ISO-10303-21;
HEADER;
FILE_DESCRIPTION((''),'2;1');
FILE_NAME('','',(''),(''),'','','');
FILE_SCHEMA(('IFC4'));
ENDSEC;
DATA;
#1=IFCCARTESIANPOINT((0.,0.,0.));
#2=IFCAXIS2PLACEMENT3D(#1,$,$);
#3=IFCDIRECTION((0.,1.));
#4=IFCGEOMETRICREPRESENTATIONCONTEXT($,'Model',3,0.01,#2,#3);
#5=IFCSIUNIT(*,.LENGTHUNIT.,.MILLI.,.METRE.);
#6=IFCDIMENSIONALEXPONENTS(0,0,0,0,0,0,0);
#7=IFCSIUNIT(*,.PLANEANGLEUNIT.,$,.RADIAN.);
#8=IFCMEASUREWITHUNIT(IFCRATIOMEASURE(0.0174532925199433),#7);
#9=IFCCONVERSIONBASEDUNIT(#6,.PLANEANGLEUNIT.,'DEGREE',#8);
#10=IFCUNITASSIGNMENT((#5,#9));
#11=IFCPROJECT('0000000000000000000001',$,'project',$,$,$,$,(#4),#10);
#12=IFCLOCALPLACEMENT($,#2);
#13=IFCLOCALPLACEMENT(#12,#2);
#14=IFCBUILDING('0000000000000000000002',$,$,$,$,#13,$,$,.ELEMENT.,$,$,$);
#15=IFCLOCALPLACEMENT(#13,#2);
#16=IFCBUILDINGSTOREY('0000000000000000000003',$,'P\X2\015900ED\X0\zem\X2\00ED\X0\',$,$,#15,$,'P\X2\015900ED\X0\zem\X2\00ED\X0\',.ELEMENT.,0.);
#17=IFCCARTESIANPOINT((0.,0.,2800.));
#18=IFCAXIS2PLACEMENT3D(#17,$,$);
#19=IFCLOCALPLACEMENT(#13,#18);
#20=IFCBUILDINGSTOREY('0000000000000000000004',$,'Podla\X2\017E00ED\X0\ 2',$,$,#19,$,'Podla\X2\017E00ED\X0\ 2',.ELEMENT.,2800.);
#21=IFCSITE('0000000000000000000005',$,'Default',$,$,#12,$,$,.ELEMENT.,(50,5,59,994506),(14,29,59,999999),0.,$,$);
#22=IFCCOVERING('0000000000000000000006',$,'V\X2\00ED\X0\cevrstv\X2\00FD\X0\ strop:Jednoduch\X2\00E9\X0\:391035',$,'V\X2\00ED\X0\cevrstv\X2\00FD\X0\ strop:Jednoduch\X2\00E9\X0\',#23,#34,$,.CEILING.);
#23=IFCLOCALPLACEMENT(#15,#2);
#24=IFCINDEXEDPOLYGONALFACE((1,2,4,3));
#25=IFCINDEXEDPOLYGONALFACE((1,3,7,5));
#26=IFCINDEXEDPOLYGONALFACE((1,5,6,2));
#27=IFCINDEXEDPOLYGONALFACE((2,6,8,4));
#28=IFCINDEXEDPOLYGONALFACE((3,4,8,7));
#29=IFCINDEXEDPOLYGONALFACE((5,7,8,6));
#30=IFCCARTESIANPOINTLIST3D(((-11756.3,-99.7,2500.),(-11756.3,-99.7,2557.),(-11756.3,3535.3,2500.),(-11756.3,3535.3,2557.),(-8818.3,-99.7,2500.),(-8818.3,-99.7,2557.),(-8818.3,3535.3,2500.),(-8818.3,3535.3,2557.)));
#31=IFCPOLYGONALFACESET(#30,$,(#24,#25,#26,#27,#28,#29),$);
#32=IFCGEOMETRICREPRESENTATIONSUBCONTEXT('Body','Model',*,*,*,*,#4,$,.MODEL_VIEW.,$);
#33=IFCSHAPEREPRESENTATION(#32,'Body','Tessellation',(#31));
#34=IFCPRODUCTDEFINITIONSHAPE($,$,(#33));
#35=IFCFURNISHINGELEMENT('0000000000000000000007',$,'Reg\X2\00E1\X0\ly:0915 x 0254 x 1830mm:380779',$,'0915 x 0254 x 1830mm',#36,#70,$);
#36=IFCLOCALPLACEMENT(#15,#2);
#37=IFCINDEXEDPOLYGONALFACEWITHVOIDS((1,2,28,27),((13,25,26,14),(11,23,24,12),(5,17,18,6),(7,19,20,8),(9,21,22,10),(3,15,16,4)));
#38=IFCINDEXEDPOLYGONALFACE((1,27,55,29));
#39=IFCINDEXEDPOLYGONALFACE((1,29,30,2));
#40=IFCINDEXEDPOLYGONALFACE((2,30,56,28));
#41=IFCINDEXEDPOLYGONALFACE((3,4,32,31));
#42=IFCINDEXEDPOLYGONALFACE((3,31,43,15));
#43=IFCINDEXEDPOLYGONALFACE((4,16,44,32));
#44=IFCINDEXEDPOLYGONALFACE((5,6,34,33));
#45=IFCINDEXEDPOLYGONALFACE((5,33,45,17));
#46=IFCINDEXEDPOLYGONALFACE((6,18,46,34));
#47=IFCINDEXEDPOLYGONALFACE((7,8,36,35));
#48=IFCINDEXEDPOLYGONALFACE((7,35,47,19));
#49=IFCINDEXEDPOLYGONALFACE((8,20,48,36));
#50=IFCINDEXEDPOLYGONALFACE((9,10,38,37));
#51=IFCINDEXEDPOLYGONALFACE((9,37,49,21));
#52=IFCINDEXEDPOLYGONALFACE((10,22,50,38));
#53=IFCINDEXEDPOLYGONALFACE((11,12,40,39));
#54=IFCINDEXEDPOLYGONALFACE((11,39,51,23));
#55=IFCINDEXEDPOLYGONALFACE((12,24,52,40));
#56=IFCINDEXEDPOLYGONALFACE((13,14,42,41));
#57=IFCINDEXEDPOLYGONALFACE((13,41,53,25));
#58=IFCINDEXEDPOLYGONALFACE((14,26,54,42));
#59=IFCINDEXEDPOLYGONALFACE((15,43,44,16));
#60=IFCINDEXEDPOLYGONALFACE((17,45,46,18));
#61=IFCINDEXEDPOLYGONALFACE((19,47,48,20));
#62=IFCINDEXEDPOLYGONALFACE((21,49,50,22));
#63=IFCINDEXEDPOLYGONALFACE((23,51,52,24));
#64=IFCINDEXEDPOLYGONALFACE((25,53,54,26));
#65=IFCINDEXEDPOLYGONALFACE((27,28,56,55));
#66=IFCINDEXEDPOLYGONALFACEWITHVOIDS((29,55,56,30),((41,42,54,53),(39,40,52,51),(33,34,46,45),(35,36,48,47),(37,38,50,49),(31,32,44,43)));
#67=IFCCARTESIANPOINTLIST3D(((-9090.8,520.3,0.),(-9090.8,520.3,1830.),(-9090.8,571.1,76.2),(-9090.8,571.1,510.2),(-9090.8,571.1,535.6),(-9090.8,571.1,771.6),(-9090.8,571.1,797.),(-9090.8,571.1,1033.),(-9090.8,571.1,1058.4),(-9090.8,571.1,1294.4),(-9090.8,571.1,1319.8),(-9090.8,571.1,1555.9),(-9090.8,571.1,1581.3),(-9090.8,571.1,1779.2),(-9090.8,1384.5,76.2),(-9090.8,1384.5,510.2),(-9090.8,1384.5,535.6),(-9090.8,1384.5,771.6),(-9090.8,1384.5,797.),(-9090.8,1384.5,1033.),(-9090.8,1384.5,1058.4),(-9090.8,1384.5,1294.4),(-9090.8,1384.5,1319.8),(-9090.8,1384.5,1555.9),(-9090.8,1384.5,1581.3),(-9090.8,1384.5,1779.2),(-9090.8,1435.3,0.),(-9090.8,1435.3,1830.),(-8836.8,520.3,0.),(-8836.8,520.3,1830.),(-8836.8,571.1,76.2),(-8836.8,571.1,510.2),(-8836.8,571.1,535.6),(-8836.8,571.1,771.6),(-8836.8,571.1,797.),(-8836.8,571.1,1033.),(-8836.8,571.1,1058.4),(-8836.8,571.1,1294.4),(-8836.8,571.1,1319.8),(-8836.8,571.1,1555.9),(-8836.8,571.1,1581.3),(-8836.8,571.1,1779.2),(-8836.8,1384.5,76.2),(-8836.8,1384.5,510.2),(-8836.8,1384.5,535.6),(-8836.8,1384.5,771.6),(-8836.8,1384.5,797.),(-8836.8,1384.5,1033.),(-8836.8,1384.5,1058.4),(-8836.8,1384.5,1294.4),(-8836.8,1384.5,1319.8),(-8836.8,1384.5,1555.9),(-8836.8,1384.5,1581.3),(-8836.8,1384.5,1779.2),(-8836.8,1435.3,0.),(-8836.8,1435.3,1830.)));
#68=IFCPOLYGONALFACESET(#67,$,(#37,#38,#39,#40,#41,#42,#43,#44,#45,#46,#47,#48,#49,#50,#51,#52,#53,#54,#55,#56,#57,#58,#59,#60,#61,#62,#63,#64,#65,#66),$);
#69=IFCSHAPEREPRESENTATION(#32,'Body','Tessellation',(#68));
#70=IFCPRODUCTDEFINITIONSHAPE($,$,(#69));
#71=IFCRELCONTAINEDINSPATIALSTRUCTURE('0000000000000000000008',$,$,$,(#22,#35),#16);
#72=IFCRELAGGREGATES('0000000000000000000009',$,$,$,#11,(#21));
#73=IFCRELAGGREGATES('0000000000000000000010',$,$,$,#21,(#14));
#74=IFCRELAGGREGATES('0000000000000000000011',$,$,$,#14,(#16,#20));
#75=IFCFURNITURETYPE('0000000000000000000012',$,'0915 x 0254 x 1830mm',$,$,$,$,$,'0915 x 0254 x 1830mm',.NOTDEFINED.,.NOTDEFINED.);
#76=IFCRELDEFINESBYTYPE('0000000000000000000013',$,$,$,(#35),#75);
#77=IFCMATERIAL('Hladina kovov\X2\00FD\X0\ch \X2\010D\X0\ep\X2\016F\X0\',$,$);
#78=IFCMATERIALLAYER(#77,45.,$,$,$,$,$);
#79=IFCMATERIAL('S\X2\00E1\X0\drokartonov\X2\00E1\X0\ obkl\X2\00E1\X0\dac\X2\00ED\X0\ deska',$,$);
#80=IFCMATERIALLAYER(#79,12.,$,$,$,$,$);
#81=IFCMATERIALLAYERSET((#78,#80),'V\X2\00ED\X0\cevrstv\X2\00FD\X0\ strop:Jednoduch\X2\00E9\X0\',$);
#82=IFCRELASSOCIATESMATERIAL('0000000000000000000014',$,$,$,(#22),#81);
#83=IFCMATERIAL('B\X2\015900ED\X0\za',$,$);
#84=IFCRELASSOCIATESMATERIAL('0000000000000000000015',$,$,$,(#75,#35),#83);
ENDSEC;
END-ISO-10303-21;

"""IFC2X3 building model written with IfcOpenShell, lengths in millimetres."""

from ifc_helpers import new_model, entity, si_unit, converted_unit, direction, frame, frame_2d, origin, place, context, subcontext, project, spatial, polyline, rectangle, outline, extrude, source, transform, mapped, material, layer, layer_set, layer_usage, type_object, type_shapes, element, save


model = new_model("IFC2X3")

# Units and contexts
model_context = context("Model", 3, precision=0.01, world=origin(), true_north=direction((0.0, 1.0)))
body_context = subcontext(model_context, "Body", "Model", "MODEL_VIEW")
ifc_project = project(units=[si_unit("LENGTHUNIT", "METRE", prefix="MILLI"), converted_unit("PLANEANGLEUNIT", "DEGREE", entity("IfcRatioMeasure", 0.0174532925199433), si_unit("PLANEANGLEUNIT", "RADIAN"), dimensions=[0, 0, 0, 0, 0, 0, 0])], contexts=[model_context])

# Site, building, storey
site_placement = place(None, origin())
site = spatial("IfcSite", under=ifc_project, at=site_placement, Name="Default", CompositionType="ELEMENT", RefLatitude=(50, 5, 59, 994506), RefLongitude=(14, 29, 59, 999999), RefElevation=0.0)
building_placement = place(site_placement, origin())
building = spatial("IfcBuilding", under=site, at=building_placement, CompositionType="ELEMENT")
storey_1_placement = place(building_placement, origin())
storey_1 = spatial("IfcBuildingStorey", under=building, at=storey_1_placement, Name="Přízemí", LongName="Přízemí", CompositionType="ELEMENT", Elevation=0.0)

# Shared definitions
ifc_material_1 = material(Name="Sádrokartonová obkládací deska")

# Shared definitions
storey_2_placement = place(building_placement, frame((0.0, 0.0, 2800.0)))
storey_2 = spatial("IfcBuildingStorey", under=building, at=storey_2_placement, Name="Podlaží 2", LongName="Podlaží 2", CompositionType="ELEMENT", Elevation=2800.0)

# Covering
ifc_material_2 = material(Name="Hladina kovových čepů")
ifc_layer_1 = layer(ifc_material_2, 45.0)
ifc_layer_2 = layer(ifc_material_1, 12.0)
ifc_layer_set_1 = layer_set([ifc_layer_1, ifc_layer_2], Name="Vícevrstvý strop:Jednoduché")
ifc_layer_usage_1 = layer_usage(ifc_layer_set_1, "AXIS3", "NEGATIVE", 0.0)
covering_1_placement = place(storey_1_placement, origin())
element("IfcCovering", 1, at=covering_1_placement, inside=storey_1, material=ifc_layer_usage_1, Name="Vícevrstvý strop:Jednoduché:391035", ObjectType="Vícevrstvý strop:Jednoduché", PredefinedType="CEILING", context=body_context, shape_type="SweptSolid", body=[
    extrude(rectangle(XDim=2938.0, YDim=3635.0, at=frame_2d((0.0, 0.0), x_axis=(1.0, 0.0))), frame((-10287.3, 1717.8, 2500.0)), (0.0, 0.0, 1.0), 57.0),
])

# Furnishing element
ifc_material_3 = material(Name="Bříza")
furniture_type = type_object("IfcFurnitureType", Name="0915 x 0254 x 1830mm", ElementType="0915 x 0254 x 1830mm", AssemblyPlace="NOTDEFINED", material=ifc_material_3)
shared_shape_1 = source(origin(), body_context, "Body", "SweptSolid", [
    extrude(outline(polyline([(-457.5, -915.0), (457.5, -915.0), (457.5, 915.0), (-457.5, 915.0), (-457.5, -915.0)]), holes=[polyline([(-406.7, 864.2), (406.7, 864.2), (406.7, 666.3), (-406.7, 666.3), (-406.7, 864.2)]), polyline([(-406.7, -838.8), (-406.7, -404.8), (406.7, -404.8), (406.7, -838.8), (-406.7, -838.8)]), polyline([(406.7, 143.4), (-406.7, 143.4), (-406.7, 379.4), (406.7, 379.4), (406.7, 143.4)]), polyline([(-406.7, 640.9), (406.7, 640.9), (406.7, 404.8), (-406.7, 404.8), (-406.7, 640.9)]), polyline([(-406.7, 118.0), (406.7, 118.0), (406.7, -118.0), (-406.7, -118.0), (-406.7, 118.0)]), polyline([(-406.7, -143.4), (406.7, -143.4), (406.7, -379.4), (-406.7, -379.4), (-406.7, -143.4)])]), frame((0.0, -431.8, 915.0), z_axis=(0.0, 1.0, 0.0), x_axis=(-1.0, 0.0, 0.0)), (0.0, 0.0, 1.0), 254.0),
])
type_shapes(furniture_type, [shared_shape_1])
furnishing_placement = place(storey_1_placement, frame((-8659.0, 977.8, 0.0), z_axis=(0.0, 0.0, 1.0), x_axis=(0.0, -1.0, 0.0)))
element("IfcFurnishingElement", 2, at=furnishing_placement, inside=storey_1, type_object=furniture_type, material=ifc_material_3, Name="Regály:0915 x 0254 x 1830mm:380779", ObjectType="0915 x 0254 x 1830mm", context=body_context, shape_type="MappedRepresentation", body=[
    mapped(shared_shape_1, transform((0.0, 0.0, 0.0), scale=1.0)),
])

save(model, "model.ifc")
